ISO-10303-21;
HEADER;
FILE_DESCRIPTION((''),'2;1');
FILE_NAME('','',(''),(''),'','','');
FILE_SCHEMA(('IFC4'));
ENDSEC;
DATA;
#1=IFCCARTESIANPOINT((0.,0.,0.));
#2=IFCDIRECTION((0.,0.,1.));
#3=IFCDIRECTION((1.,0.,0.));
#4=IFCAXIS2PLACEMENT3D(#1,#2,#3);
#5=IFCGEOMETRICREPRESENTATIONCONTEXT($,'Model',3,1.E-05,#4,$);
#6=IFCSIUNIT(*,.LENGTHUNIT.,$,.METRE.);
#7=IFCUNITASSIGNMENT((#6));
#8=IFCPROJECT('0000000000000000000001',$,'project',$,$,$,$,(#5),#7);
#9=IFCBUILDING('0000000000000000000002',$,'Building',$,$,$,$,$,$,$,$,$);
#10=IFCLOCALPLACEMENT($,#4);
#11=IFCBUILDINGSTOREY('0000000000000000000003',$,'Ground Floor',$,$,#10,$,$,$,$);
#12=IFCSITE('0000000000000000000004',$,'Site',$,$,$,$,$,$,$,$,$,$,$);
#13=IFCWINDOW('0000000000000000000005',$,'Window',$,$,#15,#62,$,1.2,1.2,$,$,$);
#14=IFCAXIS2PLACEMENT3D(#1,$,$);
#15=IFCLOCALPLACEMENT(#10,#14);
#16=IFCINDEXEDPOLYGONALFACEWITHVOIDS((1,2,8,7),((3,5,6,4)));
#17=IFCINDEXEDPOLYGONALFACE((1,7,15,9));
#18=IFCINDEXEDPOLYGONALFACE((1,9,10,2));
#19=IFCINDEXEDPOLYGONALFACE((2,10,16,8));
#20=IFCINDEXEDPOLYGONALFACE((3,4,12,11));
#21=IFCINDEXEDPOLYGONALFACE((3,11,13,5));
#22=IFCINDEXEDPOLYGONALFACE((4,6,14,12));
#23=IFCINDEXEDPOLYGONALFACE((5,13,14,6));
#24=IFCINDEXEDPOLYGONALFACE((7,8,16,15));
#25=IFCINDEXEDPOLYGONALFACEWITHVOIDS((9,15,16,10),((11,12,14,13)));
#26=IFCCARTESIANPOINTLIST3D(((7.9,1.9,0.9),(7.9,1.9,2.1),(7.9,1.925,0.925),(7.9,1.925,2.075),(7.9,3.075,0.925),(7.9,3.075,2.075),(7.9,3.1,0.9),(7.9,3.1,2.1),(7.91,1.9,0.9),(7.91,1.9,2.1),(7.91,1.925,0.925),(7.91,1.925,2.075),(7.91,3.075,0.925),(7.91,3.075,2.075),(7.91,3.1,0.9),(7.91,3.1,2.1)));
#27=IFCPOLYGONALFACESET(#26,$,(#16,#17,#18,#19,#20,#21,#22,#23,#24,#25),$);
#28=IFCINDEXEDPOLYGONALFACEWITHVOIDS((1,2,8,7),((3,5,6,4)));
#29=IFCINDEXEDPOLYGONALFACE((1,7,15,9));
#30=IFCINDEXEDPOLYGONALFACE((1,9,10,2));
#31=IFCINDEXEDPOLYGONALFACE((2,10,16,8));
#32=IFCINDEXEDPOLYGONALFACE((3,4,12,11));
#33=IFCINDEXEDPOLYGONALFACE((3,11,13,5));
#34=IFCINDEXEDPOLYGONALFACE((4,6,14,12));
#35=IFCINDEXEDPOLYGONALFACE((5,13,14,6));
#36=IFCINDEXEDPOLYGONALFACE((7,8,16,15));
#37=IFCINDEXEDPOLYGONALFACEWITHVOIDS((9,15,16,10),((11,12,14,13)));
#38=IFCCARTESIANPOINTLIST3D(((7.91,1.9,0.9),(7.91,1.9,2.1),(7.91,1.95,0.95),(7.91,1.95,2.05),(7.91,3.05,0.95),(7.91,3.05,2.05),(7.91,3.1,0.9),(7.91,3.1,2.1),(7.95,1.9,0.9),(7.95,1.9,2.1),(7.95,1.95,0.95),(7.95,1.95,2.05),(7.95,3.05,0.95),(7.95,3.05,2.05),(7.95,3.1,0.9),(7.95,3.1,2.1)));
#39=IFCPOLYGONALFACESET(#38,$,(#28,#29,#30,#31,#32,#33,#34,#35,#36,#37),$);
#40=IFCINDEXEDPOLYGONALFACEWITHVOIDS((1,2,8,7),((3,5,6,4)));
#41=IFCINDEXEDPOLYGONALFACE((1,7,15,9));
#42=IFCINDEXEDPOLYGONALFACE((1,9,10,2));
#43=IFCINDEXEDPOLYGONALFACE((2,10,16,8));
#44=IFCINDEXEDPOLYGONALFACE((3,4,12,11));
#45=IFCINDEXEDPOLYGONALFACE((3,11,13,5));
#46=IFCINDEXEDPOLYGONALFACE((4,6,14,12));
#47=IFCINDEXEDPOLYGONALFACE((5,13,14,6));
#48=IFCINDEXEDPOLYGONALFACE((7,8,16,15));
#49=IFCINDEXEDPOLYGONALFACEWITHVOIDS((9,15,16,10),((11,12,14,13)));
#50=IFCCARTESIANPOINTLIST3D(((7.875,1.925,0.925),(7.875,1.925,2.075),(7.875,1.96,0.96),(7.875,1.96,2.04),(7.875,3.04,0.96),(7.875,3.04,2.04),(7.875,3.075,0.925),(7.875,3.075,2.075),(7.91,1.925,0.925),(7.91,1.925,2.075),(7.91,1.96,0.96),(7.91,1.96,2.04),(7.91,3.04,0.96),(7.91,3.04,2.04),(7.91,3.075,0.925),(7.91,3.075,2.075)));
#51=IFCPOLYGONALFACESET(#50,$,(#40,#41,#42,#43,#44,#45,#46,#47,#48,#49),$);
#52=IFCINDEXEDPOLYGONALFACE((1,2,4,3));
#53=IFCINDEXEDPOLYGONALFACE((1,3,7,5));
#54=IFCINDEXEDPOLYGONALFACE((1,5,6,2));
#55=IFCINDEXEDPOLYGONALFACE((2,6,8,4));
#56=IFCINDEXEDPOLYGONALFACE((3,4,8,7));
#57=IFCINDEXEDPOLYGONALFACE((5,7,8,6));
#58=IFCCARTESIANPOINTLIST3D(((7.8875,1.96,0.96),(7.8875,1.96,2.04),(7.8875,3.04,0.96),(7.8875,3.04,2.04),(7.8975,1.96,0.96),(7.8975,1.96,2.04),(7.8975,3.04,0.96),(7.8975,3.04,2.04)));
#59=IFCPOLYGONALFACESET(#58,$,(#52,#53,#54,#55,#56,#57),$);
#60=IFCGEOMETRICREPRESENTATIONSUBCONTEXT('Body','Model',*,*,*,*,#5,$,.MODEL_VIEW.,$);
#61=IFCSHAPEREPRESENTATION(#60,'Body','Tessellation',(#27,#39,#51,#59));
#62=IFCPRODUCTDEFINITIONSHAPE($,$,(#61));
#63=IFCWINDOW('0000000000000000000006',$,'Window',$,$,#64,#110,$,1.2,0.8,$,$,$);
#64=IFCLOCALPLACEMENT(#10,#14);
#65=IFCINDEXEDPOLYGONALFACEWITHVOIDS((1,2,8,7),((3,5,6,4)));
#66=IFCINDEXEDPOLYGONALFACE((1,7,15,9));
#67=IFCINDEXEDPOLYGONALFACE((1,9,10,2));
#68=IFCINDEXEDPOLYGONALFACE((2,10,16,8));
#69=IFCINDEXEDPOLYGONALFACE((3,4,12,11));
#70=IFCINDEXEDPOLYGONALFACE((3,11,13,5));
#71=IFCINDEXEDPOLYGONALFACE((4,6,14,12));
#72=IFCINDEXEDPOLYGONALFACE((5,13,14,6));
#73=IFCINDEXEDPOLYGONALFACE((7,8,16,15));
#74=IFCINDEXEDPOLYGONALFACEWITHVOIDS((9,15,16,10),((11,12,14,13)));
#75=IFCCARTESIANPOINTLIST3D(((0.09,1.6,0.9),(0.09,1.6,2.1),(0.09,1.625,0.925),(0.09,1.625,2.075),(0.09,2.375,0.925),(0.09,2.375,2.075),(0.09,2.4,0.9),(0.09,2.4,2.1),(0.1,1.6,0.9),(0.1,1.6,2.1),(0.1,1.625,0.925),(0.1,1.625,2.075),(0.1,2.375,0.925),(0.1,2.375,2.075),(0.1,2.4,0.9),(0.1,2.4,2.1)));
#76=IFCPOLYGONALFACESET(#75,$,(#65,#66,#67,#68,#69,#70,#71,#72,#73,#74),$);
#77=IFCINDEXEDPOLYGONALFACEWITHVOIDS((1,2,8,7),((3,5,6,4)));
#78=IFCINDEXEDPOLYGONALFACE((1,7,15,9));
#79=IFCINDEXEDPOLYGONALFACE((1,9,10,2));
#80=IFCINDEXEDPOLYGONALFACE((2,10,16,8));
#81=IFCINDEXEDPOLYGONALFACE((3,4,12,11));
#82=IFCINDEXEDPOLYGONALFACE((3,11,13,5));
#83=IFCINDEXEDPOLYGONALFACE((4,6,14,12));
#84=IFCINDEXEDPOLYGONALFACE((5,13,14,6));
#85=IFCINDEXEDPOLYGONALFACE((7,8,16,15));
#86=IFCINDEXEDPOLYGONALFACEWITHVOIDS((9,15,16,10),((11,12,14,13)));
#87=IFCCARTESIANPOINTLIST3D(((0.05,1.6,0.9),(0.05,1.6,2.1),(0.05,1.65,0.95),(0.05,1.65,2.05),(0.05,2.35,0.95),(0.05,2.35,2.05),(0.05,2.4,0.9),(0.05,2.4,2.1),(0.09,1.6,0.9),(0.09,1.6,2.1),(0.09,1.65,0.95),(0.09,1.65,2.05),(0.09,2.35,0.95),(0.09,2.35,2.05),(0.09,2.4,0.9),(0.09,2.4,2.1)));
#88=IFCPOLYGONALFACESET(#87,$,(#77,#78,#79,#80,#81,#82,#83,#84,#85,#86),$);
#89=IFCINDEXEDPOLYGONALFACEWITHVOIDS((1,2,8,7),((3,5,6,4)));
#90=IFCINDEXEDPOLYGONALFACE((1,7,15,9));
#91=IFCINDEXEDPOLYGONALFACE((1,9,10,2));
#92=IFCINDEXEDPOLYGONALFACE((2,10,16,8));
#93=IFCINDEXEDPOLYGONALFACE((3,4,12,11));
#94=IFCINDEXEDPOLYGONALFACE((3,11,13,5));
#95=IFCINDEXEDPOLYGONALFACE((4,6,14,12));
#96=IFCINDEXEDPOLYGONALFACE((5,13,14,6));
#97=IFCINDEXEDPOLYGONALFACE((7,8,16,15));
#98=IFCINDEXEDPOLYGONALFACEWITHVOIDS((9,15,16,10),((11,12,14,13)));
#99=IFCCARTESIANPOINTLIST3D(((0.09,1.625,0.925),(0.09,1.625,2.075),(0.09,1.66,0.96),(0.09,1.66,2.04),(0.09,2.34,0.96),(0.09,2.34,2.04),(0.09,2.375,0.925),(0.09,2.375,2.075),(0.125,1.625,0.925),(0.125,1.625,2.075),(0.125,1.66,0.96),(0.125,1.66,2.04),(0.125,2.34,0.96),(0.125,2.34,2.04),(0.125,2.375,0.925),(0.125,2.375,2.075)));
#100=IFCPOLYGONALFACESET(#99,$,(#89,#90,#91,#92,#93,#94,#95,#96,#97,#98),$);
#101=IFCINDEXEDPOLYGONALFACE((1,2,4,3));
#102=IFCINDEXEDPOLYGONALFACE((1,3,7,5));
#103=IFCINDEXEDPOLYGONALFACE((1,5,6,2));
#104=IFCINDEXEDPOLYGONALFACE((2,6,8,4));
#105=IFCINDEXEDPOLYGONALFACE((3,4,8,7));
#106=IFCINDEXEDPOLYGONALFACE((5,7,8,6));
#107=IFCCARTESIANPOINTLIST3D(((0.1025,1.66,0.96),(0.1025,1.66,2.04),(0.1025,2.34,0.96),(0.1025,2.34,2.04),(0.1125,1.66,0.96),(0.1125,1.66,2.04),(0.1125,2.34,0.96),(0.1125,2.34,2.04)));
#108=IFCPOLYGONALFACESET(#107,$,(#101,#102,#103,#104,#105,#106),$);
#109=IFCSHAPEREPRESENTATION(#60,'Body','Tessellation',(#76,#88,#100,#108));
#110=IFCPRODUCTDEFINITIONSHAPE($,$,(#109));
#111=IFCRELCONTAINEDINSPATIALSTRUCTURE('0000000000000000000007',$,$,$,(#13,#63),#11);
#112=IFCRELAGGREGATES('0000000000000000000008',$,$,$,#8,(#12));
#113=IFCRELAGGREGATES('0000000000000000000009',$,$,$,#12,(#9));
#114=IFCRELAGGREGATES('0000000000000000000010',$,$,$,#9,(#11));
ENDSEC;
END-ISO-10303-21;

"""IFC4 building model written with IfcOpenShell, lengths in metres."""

from ifc_helpers import new_model, si_unit, frame, origin_with_axes, place, context, subcontext, project, spatial, line, indexed_curve, outline, extrude, element, save


model = new_model("IFC4")

# Units and contexts
model_context = context("Model", 3, precision=1e-05, world=origin_with_axes())
body_context = subcontext(model_context, "Body", "Model", "MODEL_VIEW")
ifc_project = project(units=[si_unit("LENGTHUNIT", "METRE")], contexts=[model_context])

# Site, building, storey
site = spatial("IfcSite", under=ifc_project, Name="Site")
building = spatial("IfcBuilding", under=site, Name="Building")
storey_placement = place(None, origin_with_axes())
storey = spatial("IfcBuildingStorey", under=building, at=storey_placement, Name="Ground Floor")

# Windows
window_1_placement = place(storey_placement, frame((8.0, 1.9, 0.9), z_axis=(0.0, 0.0, 1.0), x_axis=(0.0, 1.0, 0.0)))
element("IfcWindow", 1, at=window_1_placement, inside=storey, Name="Window", OverallHeight=1.2, OverallWidth=1.2, context=body_context, shape_type="SweptSolid", body=[
    extrude(outline(indexed_curve([(0.0, 0.0), (1.2, 0.0), (1.2, 1.2), (0.0, 1.2)], segments=[line(1, 2, 3, 4, 1)]), holes=[indexed_curve([(0.025, 0.025), (1.175, 0.025), (1.175, 1.175), (0.025, 1.175)], segments=[line(1, 2, 3, 4, 1)])]), frame((0.0, 0.09, 0.0), z_axis=(0.0, -1.0, 0.0), x_axis=(1.0, 0.0, 0.0)), (0.0, 0.0, -1.0), 0.01),
    extrude(outline(indexed_curve([(0.0, 0.0), (1.2, 0.0), (1.2, 1.2), (0.0, 1.2)], segments=[line(1, 2, 3, 4, 1)]), holes=[indexed_curve([(0.05, 0.05), (1.15, 0.05), (1.15, 1.15), (0.05, 1.15)], segments=[line(1, 2, 3, 4, 1)])]), frame((0.0, 0.05, 0.0), z_axis=(0.0, -1.0, 0.0), x_axis=(1.0, 0.0, 0.0)), (0.0, 0.0, -1.0), 0.04),
    extrude(outline(indexed_curve([(0.0, 0.0), (1.15, 0.0), (1.15, 1.15), (0.0, 1.15)], segments=[line(1, 2, 3, 4, 1)]), holes=[indexed_curve([(0.035, 0.035), (1.115, 0.035), (1.115, 1.115), (0.035, 1.115)], segments=[line(1, 2, 3, 4, 1)])]), frame((0.025, 0.09, 0.025), z_axis=(0.0, -1.0, 0.0), x_axis=(1.0, 0.0, 0.0)), (0.0, 0.0, -1.0), 0.035),
    extrude(outline(indexed_curve([(0.035, 0.035), (1.115, 0.035), (1.115, 1.115), (0.035, 1.115)], segments=[line(1, 2, 3, 4, 1)])), frame((0.025, 0.1025, 0.025), z_axis=(0.0, -1.0, 0.0), x_axis=(1.0, 0.0, 0.0)), (0.0, 0.0, -1.0), 0.01),
])
window_2_placement = place(storey_placement, frame((0.0, 2.4, 0.9), z_axis=(0.0, 0.0, 1.0), x_axis=(0.0, -1.0, 0.0)))
element("IfcWindow", 2, at=window_2_placement, inside=storey, Name="Window", OverallHeight=1.2, OverallWidth=0.8, context=body_context, shape_type="SweptSolid", body=[
    extrude(outline(indexed_curve([(0.0, 0.0), (0.8, 0.0), (0.8, 1.2), (0.0, 1.2)], segments=[line(1, 2, 3, 4, 1)]), holes=[indexed_curve([(0.025, 0.025), (0.775, 0.025), (0.775, 1.175), (0.025, 1.175)], segments=[line(1, 2, 3, 4, 1)])]), frame((0.0, 0.09, 0.0), z_axis=(0.0, -1.0, 0.0), x_axis=(1.0, 0.0, 0.0)), (0.0, 0.0, -1.0), 0.01),
    extrude(outline(indexed_curve([(0.0, 0.0), (0.8, 0.0), (0.8, 1.2), (0.0, 1.2)], segments=[line(1, 2, 3, 4, 1)]), holes=[indexed_curve([(0.05, 0.05), (0.75, 0.05), (0.75, 1.15), (0.05, 1.15)], segments=[line(1, 2, 3, 4, 1)])]), frame((0.0, 0.05, 0.0), z_axis=(0.0, -1.0, 0.0), x_axis=(1.0, 0.0, 0.0)), (0.0, 0.0, -1.0), 0.04),
    extrude(outline(indexed_curve([(0.0, 0.0), (0.75, 0.0), (0.75, 1.15), (0.0, 1.15)], segments=[line(1, 2, 3, 4, 1)]), holes=[indexed_curve([(0.035, 0.035), (0.715, 0.035), (0.715, 1.115), (0.035, 1.115)], segments=[line(1, 2, 3, 4, 1)])]), frame((0.025, 0.09, 0.025), z_axis=(0.0, -1.0, 0.0), x_axis=(1.0, 0.0, 0.0)), (0.0, 0.0, -1.0), 0.035),
    extrude(outline(indexed_curve([(0.035, 0.035), (0.715, 0.035), (0.715, 1.115), (0.035, 1.115)], segments=[line(1, 2, 3, 4, 1)])), frame((0.025, 0.1025, 0.025), z_axis=(0.0, -1.0, 0.0), x_axis=(1.0, 0.0, 0.0)), (0.0, 0.0, -1.0), 0.01),
])

save(model, "model.ifc")
